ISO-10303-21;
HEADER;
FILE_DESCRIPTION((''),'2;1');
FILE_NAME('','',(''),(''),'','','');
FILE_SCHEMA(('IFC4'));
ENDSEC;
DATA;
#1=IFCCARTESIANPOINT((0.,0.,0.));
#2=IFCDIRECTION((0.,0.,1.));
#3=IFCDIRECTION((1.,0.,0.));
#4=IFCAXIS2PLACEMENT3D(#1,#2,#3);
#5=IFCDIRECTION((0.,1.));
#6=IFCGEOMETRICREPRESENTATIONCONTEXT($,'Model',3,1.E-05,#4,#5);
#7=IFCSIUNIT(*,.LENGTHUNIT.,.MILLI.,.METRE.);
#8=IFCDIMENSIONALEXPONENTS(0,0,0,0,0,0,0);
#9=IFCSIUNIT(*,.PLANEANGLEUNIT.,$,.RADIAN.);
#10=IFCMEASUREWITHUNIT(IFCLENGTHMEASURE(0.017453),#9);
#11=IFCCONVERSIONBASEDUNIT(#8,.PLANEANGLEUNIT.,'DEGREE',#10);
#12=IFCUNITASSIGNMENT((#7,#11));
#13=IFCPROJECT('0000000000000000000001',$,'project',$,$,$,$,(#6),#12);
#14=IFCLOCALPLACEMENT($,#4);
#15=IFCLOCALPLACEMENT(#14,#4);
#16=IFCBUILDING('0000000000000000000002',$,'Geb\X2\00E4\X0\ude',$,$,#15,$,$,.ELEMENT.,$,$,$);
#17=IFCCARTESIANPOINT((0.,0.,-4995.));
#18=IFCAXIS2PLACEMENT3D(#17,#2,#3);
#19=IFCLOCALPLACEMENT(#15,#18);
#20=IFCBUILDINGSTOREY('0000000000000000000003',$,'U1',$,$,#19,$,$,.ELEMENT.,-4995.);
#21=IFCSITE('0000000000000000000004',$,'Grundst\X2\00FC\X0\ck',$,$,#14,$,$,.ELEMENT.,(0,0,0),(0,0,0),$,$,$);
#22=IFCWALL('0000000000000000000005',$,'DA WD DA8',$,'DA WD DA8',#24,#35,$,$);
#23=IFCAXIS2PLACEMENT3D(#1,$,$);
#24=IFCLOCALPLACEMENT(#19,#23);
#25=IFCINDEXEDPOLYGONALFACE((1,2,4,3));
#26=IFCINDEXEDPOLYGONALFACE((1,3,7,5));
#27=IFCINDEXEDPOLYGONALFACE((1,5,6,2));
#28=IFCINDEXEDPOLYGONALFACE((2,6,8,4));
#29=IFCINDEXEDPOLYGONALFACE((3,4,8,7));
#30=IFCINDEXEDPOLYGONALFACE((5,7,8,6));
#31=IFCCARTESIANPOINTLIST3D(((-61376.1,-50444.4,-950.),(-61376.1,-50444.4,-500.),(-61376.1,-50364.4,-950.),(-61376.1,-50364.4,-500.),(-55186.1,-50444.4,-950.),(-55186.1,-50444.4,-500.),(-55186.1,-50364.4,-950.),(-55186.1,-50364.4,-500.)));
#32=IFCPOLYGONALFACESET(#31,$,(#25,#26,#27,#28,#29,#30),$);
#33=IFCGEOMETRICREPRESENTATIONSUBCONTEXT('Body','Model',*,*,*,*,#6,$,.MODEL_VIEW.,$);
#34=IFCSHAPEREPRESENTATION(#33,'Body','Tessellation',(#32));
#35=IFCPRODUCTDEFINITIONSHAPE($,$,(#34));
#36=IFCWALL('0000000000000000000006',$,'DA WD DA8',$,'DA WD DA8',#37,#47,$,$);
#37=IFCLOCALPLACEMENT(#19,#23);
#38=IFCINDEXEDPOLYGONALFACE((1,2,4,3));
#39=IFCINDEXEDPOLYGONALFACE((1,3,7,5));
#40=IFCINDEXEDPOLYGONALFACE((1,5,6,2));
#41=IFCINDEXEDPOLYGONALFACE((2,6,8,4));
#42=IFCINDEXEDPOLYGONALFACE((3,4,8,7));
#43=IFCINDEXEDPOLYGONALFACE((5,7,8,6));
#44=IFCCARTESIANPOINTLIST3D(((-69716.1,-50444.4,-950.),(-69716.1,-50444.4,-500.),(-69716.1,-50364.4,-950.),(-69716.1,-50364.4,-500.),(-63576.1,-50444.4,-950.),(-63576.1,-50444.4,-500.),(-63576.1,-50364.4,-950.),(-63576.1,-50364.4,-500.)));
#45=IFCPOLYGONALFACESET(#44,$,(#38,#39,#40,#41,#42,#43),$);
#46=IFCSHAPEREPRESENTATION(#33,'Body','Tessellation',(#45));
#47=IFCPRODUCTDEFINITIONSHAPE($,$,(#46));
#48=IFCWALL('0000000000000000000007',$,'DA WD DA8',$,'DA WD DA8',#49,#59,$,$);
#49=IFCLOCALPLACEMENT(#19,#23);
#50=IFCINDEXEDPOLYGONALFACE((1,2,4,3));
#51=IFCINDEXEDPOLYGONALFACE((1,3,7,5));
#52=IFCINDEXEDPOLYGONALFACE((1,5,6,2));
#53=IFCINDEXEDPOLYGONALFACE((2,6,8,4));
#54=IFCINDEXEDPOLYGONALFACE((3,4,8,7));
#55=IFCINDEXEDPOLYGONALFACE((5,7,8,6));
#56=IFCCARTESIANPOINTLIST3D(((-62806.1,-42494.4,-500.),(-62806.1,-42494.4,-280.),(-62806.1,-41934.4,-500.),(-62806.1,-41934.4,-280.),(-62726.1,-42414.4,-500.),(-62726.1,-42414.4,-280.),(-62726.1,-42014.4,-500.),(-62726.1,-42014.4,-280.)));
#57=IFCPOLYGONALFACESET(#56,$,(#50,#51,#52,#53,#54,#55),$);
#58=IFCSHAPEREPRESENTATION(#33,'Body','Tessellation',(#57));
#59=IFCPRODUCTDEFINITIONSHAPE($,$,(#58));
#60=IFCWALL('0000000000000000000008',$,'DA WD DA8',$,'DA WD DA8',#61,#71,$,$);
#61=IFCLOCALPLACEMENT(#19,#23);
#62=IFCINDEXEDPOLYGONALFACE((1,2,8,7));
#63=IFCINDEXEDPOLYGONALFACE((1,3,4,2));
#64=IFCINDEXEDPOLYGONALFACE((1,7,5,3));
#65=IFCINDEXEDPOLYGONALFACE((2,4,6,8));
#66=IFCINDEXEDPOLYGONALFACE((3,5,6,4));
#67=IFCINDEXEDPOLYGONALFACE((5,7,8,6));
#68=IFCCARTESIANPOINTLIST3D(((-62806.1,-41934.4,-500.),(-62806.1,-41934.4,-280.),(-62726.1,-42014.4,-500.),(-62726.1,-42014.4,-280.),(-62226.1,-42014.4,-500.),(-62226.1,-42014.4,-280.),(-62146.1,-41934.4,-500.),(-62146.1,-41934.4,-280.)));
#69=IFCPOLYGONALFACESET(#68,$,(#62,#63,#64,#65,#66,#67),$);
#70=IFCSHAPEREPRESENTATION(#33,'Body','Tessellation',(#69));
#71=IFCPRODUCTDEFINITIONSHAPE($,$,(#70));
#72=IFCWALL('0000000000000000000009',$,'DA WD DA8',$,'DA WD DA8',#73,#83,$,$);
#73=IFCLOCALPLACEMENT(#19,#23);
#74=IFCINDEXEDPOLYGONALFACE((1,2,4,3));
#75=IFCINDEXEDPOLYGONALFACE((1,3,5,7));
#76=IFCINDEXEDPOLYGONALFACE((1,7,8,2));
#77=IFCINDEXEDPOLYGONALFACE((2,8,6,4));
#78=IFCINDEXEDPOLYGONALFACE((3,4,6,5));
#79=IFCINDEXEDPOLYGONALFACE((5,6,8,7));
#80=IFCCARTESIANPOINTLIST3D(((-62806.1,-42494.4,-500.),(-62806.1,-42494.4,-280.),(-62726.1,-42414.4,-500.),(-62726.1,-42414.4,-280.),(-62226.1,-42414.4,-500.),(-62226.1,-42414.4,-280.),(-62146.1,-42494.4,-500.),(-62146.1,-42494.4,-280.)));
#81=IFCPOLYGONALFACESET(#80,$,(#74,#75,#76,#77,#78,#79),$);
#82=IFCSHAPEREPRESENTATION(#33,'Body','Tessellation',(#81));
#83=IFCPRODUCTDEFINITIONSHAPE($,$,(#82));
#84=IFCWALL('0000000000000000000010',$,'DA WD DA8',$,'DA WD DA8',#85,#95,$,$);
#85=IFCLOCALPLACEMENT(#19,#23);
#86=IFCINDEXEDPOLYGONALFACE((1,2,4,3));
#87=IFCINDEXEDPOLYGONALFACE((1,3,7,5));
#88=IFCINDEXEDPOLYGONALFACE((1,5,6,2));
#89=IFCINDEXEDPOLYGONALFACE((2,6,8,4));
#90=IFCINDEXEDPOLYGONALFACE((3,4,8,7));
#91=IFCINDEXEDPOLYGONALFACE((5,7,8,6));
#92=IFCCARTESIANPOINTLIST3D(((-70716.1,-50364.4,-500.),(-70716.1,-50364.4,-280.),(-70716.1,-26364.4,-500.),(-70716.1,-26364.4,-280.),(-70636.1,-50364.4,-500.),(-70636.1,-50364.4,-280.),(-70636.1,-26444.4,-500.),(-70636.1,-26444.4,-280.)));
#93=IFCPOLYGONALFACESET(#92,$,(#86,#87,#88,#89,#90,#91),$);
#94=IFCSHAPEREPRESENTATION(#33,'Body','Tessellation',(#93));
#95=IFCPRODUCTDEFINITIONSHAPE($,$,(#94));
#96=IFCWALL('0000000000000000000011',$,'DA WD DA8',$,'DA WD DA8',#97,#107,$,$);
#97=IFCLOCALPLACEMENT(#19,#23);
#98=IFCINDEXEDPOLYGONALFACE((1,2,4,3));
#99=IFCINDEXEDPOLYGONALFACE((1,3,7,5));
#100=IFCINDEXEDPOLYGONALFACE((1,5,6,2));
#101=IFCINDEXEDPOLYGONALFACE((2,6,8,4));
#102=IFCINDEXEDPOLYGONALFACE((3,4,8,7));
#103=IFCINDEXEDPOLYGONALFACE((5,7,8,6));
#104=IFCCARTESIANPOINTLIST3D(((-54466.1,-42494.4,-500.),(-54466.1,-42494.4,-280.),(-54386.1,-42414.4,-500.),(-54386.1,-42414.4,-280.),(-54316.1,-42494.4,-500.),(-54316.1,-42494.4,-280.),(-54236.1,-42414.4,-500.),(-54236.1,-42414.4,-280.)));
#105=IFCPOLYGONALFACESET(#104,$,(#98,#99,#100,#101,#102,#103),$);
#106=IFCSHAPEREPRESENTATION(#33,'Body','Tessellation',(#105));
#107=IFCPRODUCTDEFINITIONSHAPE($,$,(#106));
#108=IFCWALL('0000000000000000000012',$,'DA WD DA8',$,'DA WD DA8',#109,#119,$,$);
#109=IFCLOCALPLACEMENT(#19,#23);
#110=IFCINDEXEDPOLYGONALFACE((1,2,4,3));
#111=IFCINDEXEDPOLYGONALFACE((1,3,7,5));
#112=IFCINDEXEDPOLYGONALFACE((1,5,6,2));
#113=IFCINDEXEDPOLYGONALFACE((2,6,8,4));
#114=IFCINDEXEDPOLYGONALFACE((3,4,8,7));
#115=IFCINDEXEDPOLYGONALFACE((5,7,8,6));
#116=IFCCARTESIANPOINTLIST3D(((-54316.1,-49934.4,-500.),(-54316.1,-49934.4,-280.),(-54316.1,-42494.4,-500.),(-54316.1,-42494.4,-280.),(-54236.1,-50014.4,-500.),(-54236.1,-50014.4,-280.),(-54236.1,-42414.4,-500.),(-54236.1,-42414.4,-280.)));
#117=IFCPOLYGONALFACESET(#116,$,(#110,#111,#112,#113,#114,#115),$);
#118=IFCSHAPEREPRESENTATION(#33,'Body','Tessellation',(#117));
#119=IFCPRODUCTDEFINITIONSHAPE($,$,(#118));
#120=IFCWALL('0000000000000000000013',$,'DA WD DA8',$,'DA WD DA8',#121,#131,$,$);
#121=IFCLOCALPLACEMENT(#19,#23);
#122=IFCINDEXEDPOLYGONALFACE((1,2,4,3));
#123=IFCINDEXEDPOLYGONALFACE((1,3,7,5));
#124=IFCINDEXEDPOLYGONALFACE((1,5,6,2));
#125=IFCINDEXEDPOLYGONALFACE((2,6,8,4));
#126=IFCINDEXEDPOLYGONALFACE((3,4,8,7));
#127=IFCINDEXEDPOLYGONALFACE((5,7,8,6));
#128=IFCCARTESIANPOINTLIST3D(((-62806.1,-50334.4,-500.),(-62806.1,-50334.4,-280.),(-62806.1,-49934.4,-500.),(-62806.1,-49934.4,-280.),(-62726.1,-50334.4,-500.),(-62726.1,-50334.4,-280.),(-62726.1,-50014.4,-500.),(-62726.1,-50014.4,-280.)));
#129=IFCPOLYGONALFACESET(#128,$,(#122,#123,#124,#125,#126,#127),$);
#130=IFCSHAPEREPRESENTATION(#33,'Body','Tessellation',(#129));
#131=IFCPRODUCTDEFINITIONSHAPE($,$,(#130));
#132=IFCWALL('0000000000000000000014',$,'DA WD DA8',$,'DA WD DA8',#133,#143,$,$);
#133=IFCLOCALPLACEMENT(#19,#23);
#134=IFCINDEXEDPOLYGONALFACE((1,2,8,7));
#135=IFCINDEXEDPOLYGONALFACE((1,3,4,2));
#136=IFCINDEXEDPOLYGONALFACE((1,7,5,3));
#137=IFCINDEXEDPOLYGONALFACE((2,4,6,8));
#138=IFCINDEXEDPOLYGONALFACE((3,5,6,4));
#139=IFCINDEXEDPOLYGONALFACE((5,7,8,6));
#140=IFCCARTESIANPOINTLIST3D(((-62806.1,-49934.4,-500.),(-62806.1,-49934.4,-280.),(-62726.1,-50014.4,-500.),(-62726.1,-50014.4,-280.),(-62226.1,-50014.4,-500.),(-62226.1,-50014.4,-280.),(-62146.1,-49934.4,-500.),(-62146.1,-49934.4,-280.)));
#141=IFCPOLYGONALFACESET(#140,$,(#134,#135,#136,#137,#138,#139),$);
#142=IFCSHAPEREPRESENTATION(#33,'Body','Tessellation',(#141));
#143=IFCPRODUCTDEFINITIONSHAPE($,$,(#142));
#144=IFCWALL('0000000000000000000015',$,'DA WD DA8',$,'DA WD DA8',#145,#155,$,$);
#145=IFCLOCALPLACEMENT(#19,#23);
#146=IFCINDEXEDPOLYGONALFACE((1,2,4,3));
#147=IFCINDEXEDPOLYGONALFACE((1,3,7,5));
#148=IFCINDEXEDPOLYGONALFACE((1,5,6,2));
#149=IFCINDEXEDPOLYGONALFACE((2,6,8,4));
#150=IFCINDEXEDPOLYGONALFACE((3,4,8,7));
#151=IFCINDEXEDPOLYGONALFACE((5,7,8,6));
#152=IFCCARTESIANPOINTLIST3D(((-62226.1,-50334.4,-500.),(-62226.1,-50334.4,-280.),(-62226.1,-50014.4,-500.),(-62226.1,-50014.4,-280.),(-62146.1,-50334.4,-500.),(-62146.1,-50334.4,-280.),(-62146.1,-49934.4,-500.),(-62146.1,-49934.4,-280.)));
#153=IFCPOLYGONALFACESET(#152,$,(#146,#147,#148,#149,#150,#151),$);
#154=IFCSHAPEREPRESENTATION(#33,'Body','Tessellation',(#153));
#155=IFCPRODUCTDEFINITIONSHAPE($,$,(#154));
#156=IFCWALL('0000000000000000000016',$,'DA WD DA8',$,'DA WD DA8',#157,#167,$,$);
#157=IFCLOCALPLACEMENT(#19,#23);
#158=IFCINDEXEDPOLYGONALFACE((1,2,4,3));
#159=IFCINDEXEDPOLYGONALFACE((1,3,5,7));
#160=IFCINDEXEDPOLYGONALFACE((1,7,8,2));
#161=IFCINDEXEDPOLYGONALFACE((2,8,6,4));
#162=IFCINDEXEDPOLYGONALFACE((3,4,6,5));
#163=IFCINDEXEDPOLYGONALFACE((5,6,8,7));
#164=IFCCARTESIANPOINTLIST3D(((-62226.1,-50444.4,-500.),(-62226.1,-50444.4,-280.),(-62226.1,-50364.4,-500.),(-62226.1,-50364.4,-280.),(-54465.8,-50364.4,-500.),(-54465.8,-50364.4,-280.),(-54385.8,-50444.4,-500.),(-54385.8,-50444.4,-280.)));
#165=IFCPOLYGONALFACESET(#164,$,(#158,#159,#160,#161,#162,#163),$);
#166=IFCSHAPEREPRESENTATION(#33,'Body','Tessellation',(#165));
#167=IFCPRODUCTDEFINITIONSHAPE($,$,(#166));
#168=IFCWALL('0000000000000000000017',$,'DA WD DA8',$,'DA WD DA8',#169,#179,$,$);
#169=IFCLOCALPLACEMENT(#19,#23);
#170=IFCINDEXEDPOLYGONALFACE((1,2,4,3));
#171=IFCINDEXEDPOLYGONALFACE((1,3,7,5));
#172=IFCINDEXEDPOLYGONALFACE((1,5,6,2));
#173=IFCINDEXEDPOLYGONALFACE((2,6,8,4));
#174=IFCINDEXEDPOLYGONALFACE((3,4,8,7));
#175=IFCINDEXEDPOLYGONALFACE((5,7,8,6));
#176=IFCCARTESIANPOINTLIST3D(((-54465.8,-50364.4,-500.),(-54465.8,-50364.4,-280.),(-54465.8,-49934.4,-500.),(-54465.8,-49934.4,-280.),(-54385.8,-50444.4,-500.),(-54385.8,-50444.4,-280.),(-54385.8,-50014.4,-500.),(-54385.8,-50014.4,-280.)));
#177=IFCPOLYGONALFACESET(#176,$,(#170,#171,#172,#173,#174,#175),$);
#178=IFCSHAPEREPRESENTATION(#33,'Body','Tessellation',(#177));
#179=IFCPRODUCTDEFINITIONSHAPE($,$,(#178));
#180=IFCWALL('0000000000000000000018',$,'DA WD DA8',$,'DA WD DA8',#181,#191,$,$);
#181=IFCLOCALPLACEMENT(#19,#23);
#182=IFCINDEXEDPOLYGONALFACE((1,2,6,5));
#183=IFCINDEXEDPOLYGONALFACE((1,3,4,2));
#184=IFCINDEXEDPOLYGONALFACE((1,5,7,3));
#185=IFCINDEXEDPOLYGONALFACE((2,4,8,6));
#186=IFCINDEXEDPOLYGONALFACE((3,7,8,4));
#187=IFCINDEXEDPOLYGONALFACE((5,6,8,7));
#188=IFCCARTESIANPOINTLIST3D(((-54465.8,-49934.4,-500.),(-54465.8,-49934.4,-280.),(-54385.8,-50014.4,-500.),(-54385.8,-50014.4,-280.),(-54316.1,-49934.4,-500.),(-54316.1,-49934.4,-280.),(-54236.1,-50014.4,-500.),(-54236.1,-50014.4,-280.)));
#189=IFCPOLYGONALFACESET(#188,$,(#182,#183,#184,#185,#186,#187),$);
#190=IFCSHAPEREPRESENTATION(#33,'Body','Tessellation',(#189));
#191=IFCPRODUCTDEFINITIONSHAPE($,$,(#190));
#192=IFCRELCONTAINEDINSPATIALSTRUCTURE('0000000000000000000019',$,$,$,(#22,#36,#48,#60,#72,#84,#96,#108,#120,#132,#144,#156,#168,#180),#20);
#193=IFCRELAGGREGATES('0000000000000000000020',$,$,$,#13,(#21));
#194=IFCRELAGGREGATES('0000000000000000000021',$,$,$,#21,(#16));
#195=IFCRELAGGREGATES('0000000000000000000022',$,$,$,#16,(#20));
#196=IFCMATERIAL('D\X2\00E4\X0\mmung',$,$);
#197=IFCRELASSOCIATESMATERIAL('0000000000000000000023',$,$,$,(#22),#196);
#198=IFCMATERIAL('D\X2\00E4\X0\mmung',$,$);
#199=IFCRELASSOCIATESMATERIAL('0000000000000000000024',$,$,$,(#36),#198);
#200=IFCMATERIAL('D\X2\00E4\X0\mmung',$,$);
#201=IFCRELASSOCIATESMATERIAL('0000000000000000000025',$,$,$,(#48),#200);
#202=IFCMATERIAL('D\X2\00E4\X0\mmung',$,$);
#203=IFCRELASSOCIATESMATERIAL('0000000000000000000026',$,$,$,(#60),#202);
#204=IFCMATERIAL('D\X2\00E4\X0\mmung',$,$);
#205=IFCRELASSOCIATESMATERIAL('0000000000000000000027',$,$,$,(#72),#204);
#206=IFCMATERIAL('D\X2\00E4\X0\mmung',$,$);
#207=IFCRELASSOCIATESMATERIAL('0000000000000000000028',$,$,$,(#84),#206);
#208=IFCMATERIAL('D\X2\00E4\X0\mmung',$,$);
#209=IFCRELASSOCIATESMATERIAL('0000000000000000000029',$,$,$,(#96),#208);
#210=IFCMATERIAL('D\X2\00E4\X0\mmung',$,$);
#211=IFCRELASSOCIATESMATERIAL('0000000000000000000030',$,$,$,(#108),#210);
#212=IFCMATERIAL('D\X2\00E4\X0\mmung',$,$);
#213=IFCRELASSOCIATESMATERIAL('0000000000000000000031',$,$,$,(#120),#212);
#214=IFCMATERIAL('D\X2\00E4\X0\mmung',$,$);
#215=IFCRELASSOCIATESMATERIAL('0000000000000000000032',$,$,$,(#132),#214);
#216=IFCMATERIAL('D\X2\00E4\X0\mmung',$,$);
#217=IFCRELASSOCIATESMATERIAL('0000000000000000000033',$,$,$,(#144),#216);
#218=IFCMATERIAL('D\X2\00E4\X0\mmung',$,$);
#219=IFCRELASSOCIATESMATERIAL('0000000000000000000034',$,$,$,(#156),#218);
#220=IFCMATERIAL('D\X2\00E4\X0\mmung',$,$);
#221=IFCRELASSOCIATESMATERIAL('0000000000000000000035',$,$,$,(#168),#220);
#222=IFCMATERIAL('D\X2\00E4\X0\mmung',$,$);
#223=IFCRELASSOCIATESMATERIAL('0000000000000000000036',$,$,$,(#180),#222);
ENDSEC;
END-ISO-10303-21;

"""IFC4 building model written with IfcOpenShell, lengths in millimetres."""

from ifc_helpers import new_model, entity, si_unit, converted_unit, direction, frame, origin_with_axes, place, context, subcontext, project, spatial, line, indexed_curve, outline, extrude, material, element, save


model = new_model("IFC4")

# Units and contexts
model_context = context("Model", 3, precision=1e-05, world=origin_with_axes(), true_north=direction((0.0, 1.0)))
body_context = subcontext(model_context, "Body", "Model", "MODEL_VIEW")
ifc_project = project(units=[si_unit("LENGTHUNIT", "METRE", prefix="MILLI"), converted_unit("PLANEANGLEUNIT", "DEGREE", entity("IfcLengthMeasure", 0.017453), si_unit("PLANEANGLEUNIT", "RADIAN"), dimensions=[0, 0, 0, 0, 0, 0, 0])], contexts=[model_context])

# Site, building, storey
site_placement = place(None, origin_with_axes())
site = spatial("IfcSite", under=ifc_project, at=site_placement, Name="Grundstück", CompositionType="ELEMENT", RefLatitude=(0, 0, 0), RefLongitude=(0, 0, 0))
building_placement = place(site_placement, origin_with_axes())
building = spatial("IfcBuilding", under=site, at=building_placement, Name="Gebäude", CompositionType="ELEMENT")
storey_placement = place(building_placement, frame((0.0, 0.0, -4995.0), z_axis=(0.0, 0.0, 1.0), x_axis=(1.0, 0.0, 0.0)))
storey = spatial("IfcBuildingStorey", under=building, at=storey_placement, Name="U1", CompositionType="ELEMENT", Elevation=-4995.0)

# Walls
ifc_material_1 = material(Name="Dämmung")
wall_1_placement = place(storey_placement, frame((-55186.1, -50404.4, -950.0), z_axis=(0.0, 0.0, 1.0), x_axis=(-1.0, 0.0, 0.0)))
element("IfcWall", 1, at=wall_1_placement, inside=storey, material=ifc_material_1, Name="DA WD DA8", ObjectType="DA WD DA8", context=body_context, shape_type="SweptSolid", body=[
    extrude(outline(indexed_curve([(0.0, -40.0), (0.0, 40.0), (6190.0, 40.0), (6190.0, -40.0)], segments=[line(1, 2), line(2, 3), line(3, 4), line(4, 1)])), origin_with_axes(), (0.0, 0.0, 1.0), 450.0),
])
ifc_material_2 = material(Name="Dämmung")
wall_2_placement = place(storey_placement, frame((-63576.1, -50404.4, -950.0), z_axis=(0.0, 0.0, 1.0), x_axis=(-1.0, 0.0, 0.0)))
element("IfcWall", 2, at=wall_2_placement, inside=storey, material=ifc_material_2, Name="DA WD DA8", ObjectType="DA WD DA8", context=body_context, shape_type="SweptSolid", body=[
    extrude(outline(indexed_curve([(0.0, -40.0), (0.0, 40.0), (6140.0, 40.0), (6140.0, -40.0)], segments=[line(1, 2), line(2, 3), line(3, 4), line(4, 1)])), origin_with_axes(), (0.0, 0.0, 1.0), 450.0),
])
ifc_material_3 = material(Name="Dämmung")
wall_3_placement = place(storey_placement, frame((-62766.1, -42454.4, -500.0), z_axis=(0.0, 0.0, 1.0), x_axis=(0.0, 1.0, 0.0)))
element("IfcWall", 3, at=wall_3_placement, inside=storey, material=ifc_material_3, Name="DA WD DA8", ObjectType="DA WD DA8", context=body_context, shape_type="SweptSolid", body=[
    extrude(outline(indexed_curve([(40.0, -40.0), (-40.0, 40.0), (520.0, 40.0), (440.0, -40.0)], segments=[line(1, 2), line(2, 3), line(3, 4), line(4, 1)])), origin_with_axes(), (0.0, 0.0, 1.0), 220.0),
])
ifc_material_4 = material(Name="Dämmung")
wall_4_placement = place(storey_placement, frame((-62766.1, -41974.4, -500.0), z_axis=(0.0, 0.0, 1.0), x_axis=(1.0, 0.0, 0.0)))
element("IfcWall", 4, at=wall_4_placement, inside=storey, material=ifc_material_4, Name="DA WD DA8", ObjectType="DA WD DA8", context=body_context, shape_type="SweptSolid", body=[
    extrude(outline(indexed_curve([(40.0, -40.0), (-40.0, 40.0), (620.0, 40.0), (540.0, -40.0)], segments=[line(1, 2), line(2, 3), line(3, 4), line(4, 1)])), origin_with_axes(), (0.0, 0.0, 1.0), 220.0),
])
ifc_material_5 = material(Name="Dämmung")
wall_5_placement = place(storey_placement, frame((-62186.1, -42454.4, -500.0), z_axis=(0.0, 0.0, 1.0), x_axis=(-1.0, 0.0, 0.0)))
element("IfcWall", 5, at=wall_5_placement, inside=storey, material=ifc_material_5, Name="DA WD DA8", ObjectType="DA WD DA8", context=body_context, shape_type="SweptSolid", body=[
    extrude(outline(indexed_curve([(40.0, -40.0), (-40.0, 40.0), (620.0, 40.0), (540.0, -40.0)], segments=[line(1, 2), line(2, 3), line(3, 4), line(4, 1)])), origin_with_axes(), (0.0, 0.0, 1.0), 220.0),
])
ifc_material_6 = material(Name="Dämmung")
wall_6_placement = place(storey_placement, frame((-70676.1, -50364.4, -500.0), z_axis=(0.0, 0.0, 1.0), x_axis=(0.0, 1.0, 0.0)))
element("IfcWall", 6, at=wall_6_placement, inside=storey, material=ifc_material_6, Name="DA WD DA8", ObjectType="DA WD DA8", context=body_context, shape_type="SweptSolid", body=[
    extrude(outline(indexed_curve([(0.0, -40.0), (0.0, 40.0), (24000.0, 40.0), (23920.0, -40.0)], segments=[line(1, 2), line(2, 3), line(3, 4), line(4, 1)])), origin_with_axes(), (0.0, 0.0, 1.0), 220.0),
])
ifc_material_7 = material(Name="Dämmung")
wall_7_placement = place(storey_placement, frame((-54426.1, -42454.4, -500.0), z_axis=(0.0, 0.0, 1.0), x_axis=(1.0, 0.0, 0.0)))
element("IfcWall", 7, at=wall_7_placement, inside=storey, material=ifc_material_7, Name="DA WD DA8", ObjectType="DA WD DA8", context=body_context, shape_type="SweptSolid", body=[
    extrude(outline(indexed_curve([(-40.0, -40.0), (40.0, 40.0), (190.0, 40.0), (110.0, -40.0)], segments=[line(1, 2), line(2, 3), line(3, 4), line(4, 1)])), origin_with_axes(), (0.0, 0.0, 1.0), 220.0),
])
ifc_material_8 = material(Name="Dämmung")
wall_8_placement = place(storey_placement, frame((-54276.1, -42454.4, -500.0), z_axis=(0.0, 0.0, 1.0), x_axis=(0.0, -1.0, 0.0)))
element("IfcWall", 8, at=wall_8_placement, inside=storey, material=ifc_material_8, Name="DA WD DA8", ObjectType="DA WD DA8", context=body_context, shape_type="SweptSolid", body=[
    extrude(outline(indexed_curve([(40.0, -40.0), (-40.0, 40.0), (7560.0, 40.0), (7480.0, -40.0)], segments=[line(1, 2), line(2, 3), line(3, 4), line(4, 1)])), origin_with_axes(), (0.0, 0.0, 1.0), 220.0),
])
ifc_material_9 = material(Name="Dämmung")
wall_9_placement = place(storey_placement, frame((-62766.1, -50334.4, -500.0), z_axis=(0.0, 0.0, 1.0), x_axis=(0.0, 1.0, 0.0)))
element("IfcWall", 9, at=wall_9_placement, inside=storey, material=ifc_material_9, Name="DA WD DA8", ObjectType="DA WD DA8", context=body_context, shape_type="SweptSolid", body=[
    extrude(outline(indexed_curve([(0.0, -40.0), (0.0, 40.0), (400.0, 40.0), (320.0, -40.0)], segments=[line(1, 2), line(2, 3), line(3, 4), line(4, 1)])), origin_with_axes(), (0.0, 0.0, 1.0), 220.0),
])
ifc_material_10 = material(Name="Dämmung")
wall_10_placement = place(storey_placement, frame((-62766.1, -49974.4, -500.0), z_axis=(0.0, 0.0, 1.0), x_axis=(1.0, 0.0, 0.0)))
element("IfcWall", 10, at=wall_10_placement, inside=storey, material=ifc_material_10, Name="DA WD DA8", ObjectType="DA WD DA8", context=body_context, shape_type="SweptSolid", body=[
    extrude(outline(indexed_curve([(40.0, -40.0), (-40.0, 40.0), (620.0, 40.0), (540.0, -40.0)], segments=[line(1, 2), line(2, 3), line(3, 4), line(4, 1)])), origin_with_axes(), (0.0, 0.0, 1.0), 220.0),
])
ifc_material_11 = material(Name="Dämmung")
wall_11_placement = place(storey_placement, frame((-62186.1, -49974.4, -500.0), z_axis=(0.0, 0.0, 1.0), x_axis=(0.0, -1.0, 0.0)))
element("IfcWall", 11, at=wall_11_placement, inside=storey, material=ifc_material_11, Name="DA WD DA8", ObjectType="DA WD DA8", context=body_context, shape_type="SweptSolid", body=[
    extrude(outline(indexed_curve([(40.0, -40.0), (-40.0, 40.0), (360.0, 40.0), (360.0, -40.0)], segments=[line(1, 2), line(2, 3), line(3, 4), line(4, 1)])), origin_with_axes(), (0.0, 0.0, 1.0), 220.0),
])
ifc_material_12 = material(Name="Dämmung")
wall_12_placement = place(storey_placement, frame((-62226.1, -50404.4, -500.0), z_axis=(0.0, 0.0, 1.0), x_axis=(1.0, 0.0, 0.0)))
element("IfcWall", 12, at=wall_12_placement, inside=storey, material=ifc_material_12, Name="DA WD DA8", ObjectType="DA WD DA8", context=body_context, shape_type="SweptSolid", body=[
    extrude(outline(indexed_curve([(0.0, -40.0), (0.0, 40.0), (7760.3, 40.0), (7840.3, -40.0)], segments=[line(1, 2), line(2, 3), line(3, 4), line(4, 1)])), origin_with_axes(), (0.0, 0.0, 1.0), 220.0),
])
ifc_material_13 = material(Name="Dämmung")
wall_13_placement = place(storey_placement, frame((-54425.8, -50404.4, -500.0), z_axis=(0.0, 0.0, 1.0), x_axis=(0.0, 1.0, 0.0)))
element("IfcWall", 13, at=wall_13_placement, inside=storey, material=ifc_material_13, Name="DA WD DA8", ObjectType="DA WD DA8", context=body_context, shape_type="SweptSolid", body=[
    extrude(outline(indexed_curve([(-40.0, -40.0), (40.0, 40.0), (470.0, 40.0), (390.0, -40.0)], segments=[line(1, 2), line(2, 3), line(3, 4), line(4, 1)])), origin_with_axes(), (0.0, 0.0, 1.0), 220.0),
])
ifc_material_14 = material(Name="Dämmung")
wall_14_placement = place(storey_placement, frame((-54425.8, -49974.4, -500.0), z_axis=(0.0, 0.0, 1.0), x_axis=(1.0, 0.0, 0.0)))
element("IfcWall", 14, at=wall_14_placement, inside=storey, material=ifc_material_14, Name="DA WD DA8", ObjectType="DA WD DA8", context=body_context, shape_type="SweptSolid", body=[
    extrude(outline(indexed_curve([(40.0, -40.0), (-40.0, 40.0), (109.7, 40.0), (189.7, -40.0)], segments=[line(1, 2), line(2, 3), line(3, 4), line(4, 1)])), origin_with_axes(), (0.0, 0.0, 1.0), 220.0),
])

save(model, "model.ifc")
